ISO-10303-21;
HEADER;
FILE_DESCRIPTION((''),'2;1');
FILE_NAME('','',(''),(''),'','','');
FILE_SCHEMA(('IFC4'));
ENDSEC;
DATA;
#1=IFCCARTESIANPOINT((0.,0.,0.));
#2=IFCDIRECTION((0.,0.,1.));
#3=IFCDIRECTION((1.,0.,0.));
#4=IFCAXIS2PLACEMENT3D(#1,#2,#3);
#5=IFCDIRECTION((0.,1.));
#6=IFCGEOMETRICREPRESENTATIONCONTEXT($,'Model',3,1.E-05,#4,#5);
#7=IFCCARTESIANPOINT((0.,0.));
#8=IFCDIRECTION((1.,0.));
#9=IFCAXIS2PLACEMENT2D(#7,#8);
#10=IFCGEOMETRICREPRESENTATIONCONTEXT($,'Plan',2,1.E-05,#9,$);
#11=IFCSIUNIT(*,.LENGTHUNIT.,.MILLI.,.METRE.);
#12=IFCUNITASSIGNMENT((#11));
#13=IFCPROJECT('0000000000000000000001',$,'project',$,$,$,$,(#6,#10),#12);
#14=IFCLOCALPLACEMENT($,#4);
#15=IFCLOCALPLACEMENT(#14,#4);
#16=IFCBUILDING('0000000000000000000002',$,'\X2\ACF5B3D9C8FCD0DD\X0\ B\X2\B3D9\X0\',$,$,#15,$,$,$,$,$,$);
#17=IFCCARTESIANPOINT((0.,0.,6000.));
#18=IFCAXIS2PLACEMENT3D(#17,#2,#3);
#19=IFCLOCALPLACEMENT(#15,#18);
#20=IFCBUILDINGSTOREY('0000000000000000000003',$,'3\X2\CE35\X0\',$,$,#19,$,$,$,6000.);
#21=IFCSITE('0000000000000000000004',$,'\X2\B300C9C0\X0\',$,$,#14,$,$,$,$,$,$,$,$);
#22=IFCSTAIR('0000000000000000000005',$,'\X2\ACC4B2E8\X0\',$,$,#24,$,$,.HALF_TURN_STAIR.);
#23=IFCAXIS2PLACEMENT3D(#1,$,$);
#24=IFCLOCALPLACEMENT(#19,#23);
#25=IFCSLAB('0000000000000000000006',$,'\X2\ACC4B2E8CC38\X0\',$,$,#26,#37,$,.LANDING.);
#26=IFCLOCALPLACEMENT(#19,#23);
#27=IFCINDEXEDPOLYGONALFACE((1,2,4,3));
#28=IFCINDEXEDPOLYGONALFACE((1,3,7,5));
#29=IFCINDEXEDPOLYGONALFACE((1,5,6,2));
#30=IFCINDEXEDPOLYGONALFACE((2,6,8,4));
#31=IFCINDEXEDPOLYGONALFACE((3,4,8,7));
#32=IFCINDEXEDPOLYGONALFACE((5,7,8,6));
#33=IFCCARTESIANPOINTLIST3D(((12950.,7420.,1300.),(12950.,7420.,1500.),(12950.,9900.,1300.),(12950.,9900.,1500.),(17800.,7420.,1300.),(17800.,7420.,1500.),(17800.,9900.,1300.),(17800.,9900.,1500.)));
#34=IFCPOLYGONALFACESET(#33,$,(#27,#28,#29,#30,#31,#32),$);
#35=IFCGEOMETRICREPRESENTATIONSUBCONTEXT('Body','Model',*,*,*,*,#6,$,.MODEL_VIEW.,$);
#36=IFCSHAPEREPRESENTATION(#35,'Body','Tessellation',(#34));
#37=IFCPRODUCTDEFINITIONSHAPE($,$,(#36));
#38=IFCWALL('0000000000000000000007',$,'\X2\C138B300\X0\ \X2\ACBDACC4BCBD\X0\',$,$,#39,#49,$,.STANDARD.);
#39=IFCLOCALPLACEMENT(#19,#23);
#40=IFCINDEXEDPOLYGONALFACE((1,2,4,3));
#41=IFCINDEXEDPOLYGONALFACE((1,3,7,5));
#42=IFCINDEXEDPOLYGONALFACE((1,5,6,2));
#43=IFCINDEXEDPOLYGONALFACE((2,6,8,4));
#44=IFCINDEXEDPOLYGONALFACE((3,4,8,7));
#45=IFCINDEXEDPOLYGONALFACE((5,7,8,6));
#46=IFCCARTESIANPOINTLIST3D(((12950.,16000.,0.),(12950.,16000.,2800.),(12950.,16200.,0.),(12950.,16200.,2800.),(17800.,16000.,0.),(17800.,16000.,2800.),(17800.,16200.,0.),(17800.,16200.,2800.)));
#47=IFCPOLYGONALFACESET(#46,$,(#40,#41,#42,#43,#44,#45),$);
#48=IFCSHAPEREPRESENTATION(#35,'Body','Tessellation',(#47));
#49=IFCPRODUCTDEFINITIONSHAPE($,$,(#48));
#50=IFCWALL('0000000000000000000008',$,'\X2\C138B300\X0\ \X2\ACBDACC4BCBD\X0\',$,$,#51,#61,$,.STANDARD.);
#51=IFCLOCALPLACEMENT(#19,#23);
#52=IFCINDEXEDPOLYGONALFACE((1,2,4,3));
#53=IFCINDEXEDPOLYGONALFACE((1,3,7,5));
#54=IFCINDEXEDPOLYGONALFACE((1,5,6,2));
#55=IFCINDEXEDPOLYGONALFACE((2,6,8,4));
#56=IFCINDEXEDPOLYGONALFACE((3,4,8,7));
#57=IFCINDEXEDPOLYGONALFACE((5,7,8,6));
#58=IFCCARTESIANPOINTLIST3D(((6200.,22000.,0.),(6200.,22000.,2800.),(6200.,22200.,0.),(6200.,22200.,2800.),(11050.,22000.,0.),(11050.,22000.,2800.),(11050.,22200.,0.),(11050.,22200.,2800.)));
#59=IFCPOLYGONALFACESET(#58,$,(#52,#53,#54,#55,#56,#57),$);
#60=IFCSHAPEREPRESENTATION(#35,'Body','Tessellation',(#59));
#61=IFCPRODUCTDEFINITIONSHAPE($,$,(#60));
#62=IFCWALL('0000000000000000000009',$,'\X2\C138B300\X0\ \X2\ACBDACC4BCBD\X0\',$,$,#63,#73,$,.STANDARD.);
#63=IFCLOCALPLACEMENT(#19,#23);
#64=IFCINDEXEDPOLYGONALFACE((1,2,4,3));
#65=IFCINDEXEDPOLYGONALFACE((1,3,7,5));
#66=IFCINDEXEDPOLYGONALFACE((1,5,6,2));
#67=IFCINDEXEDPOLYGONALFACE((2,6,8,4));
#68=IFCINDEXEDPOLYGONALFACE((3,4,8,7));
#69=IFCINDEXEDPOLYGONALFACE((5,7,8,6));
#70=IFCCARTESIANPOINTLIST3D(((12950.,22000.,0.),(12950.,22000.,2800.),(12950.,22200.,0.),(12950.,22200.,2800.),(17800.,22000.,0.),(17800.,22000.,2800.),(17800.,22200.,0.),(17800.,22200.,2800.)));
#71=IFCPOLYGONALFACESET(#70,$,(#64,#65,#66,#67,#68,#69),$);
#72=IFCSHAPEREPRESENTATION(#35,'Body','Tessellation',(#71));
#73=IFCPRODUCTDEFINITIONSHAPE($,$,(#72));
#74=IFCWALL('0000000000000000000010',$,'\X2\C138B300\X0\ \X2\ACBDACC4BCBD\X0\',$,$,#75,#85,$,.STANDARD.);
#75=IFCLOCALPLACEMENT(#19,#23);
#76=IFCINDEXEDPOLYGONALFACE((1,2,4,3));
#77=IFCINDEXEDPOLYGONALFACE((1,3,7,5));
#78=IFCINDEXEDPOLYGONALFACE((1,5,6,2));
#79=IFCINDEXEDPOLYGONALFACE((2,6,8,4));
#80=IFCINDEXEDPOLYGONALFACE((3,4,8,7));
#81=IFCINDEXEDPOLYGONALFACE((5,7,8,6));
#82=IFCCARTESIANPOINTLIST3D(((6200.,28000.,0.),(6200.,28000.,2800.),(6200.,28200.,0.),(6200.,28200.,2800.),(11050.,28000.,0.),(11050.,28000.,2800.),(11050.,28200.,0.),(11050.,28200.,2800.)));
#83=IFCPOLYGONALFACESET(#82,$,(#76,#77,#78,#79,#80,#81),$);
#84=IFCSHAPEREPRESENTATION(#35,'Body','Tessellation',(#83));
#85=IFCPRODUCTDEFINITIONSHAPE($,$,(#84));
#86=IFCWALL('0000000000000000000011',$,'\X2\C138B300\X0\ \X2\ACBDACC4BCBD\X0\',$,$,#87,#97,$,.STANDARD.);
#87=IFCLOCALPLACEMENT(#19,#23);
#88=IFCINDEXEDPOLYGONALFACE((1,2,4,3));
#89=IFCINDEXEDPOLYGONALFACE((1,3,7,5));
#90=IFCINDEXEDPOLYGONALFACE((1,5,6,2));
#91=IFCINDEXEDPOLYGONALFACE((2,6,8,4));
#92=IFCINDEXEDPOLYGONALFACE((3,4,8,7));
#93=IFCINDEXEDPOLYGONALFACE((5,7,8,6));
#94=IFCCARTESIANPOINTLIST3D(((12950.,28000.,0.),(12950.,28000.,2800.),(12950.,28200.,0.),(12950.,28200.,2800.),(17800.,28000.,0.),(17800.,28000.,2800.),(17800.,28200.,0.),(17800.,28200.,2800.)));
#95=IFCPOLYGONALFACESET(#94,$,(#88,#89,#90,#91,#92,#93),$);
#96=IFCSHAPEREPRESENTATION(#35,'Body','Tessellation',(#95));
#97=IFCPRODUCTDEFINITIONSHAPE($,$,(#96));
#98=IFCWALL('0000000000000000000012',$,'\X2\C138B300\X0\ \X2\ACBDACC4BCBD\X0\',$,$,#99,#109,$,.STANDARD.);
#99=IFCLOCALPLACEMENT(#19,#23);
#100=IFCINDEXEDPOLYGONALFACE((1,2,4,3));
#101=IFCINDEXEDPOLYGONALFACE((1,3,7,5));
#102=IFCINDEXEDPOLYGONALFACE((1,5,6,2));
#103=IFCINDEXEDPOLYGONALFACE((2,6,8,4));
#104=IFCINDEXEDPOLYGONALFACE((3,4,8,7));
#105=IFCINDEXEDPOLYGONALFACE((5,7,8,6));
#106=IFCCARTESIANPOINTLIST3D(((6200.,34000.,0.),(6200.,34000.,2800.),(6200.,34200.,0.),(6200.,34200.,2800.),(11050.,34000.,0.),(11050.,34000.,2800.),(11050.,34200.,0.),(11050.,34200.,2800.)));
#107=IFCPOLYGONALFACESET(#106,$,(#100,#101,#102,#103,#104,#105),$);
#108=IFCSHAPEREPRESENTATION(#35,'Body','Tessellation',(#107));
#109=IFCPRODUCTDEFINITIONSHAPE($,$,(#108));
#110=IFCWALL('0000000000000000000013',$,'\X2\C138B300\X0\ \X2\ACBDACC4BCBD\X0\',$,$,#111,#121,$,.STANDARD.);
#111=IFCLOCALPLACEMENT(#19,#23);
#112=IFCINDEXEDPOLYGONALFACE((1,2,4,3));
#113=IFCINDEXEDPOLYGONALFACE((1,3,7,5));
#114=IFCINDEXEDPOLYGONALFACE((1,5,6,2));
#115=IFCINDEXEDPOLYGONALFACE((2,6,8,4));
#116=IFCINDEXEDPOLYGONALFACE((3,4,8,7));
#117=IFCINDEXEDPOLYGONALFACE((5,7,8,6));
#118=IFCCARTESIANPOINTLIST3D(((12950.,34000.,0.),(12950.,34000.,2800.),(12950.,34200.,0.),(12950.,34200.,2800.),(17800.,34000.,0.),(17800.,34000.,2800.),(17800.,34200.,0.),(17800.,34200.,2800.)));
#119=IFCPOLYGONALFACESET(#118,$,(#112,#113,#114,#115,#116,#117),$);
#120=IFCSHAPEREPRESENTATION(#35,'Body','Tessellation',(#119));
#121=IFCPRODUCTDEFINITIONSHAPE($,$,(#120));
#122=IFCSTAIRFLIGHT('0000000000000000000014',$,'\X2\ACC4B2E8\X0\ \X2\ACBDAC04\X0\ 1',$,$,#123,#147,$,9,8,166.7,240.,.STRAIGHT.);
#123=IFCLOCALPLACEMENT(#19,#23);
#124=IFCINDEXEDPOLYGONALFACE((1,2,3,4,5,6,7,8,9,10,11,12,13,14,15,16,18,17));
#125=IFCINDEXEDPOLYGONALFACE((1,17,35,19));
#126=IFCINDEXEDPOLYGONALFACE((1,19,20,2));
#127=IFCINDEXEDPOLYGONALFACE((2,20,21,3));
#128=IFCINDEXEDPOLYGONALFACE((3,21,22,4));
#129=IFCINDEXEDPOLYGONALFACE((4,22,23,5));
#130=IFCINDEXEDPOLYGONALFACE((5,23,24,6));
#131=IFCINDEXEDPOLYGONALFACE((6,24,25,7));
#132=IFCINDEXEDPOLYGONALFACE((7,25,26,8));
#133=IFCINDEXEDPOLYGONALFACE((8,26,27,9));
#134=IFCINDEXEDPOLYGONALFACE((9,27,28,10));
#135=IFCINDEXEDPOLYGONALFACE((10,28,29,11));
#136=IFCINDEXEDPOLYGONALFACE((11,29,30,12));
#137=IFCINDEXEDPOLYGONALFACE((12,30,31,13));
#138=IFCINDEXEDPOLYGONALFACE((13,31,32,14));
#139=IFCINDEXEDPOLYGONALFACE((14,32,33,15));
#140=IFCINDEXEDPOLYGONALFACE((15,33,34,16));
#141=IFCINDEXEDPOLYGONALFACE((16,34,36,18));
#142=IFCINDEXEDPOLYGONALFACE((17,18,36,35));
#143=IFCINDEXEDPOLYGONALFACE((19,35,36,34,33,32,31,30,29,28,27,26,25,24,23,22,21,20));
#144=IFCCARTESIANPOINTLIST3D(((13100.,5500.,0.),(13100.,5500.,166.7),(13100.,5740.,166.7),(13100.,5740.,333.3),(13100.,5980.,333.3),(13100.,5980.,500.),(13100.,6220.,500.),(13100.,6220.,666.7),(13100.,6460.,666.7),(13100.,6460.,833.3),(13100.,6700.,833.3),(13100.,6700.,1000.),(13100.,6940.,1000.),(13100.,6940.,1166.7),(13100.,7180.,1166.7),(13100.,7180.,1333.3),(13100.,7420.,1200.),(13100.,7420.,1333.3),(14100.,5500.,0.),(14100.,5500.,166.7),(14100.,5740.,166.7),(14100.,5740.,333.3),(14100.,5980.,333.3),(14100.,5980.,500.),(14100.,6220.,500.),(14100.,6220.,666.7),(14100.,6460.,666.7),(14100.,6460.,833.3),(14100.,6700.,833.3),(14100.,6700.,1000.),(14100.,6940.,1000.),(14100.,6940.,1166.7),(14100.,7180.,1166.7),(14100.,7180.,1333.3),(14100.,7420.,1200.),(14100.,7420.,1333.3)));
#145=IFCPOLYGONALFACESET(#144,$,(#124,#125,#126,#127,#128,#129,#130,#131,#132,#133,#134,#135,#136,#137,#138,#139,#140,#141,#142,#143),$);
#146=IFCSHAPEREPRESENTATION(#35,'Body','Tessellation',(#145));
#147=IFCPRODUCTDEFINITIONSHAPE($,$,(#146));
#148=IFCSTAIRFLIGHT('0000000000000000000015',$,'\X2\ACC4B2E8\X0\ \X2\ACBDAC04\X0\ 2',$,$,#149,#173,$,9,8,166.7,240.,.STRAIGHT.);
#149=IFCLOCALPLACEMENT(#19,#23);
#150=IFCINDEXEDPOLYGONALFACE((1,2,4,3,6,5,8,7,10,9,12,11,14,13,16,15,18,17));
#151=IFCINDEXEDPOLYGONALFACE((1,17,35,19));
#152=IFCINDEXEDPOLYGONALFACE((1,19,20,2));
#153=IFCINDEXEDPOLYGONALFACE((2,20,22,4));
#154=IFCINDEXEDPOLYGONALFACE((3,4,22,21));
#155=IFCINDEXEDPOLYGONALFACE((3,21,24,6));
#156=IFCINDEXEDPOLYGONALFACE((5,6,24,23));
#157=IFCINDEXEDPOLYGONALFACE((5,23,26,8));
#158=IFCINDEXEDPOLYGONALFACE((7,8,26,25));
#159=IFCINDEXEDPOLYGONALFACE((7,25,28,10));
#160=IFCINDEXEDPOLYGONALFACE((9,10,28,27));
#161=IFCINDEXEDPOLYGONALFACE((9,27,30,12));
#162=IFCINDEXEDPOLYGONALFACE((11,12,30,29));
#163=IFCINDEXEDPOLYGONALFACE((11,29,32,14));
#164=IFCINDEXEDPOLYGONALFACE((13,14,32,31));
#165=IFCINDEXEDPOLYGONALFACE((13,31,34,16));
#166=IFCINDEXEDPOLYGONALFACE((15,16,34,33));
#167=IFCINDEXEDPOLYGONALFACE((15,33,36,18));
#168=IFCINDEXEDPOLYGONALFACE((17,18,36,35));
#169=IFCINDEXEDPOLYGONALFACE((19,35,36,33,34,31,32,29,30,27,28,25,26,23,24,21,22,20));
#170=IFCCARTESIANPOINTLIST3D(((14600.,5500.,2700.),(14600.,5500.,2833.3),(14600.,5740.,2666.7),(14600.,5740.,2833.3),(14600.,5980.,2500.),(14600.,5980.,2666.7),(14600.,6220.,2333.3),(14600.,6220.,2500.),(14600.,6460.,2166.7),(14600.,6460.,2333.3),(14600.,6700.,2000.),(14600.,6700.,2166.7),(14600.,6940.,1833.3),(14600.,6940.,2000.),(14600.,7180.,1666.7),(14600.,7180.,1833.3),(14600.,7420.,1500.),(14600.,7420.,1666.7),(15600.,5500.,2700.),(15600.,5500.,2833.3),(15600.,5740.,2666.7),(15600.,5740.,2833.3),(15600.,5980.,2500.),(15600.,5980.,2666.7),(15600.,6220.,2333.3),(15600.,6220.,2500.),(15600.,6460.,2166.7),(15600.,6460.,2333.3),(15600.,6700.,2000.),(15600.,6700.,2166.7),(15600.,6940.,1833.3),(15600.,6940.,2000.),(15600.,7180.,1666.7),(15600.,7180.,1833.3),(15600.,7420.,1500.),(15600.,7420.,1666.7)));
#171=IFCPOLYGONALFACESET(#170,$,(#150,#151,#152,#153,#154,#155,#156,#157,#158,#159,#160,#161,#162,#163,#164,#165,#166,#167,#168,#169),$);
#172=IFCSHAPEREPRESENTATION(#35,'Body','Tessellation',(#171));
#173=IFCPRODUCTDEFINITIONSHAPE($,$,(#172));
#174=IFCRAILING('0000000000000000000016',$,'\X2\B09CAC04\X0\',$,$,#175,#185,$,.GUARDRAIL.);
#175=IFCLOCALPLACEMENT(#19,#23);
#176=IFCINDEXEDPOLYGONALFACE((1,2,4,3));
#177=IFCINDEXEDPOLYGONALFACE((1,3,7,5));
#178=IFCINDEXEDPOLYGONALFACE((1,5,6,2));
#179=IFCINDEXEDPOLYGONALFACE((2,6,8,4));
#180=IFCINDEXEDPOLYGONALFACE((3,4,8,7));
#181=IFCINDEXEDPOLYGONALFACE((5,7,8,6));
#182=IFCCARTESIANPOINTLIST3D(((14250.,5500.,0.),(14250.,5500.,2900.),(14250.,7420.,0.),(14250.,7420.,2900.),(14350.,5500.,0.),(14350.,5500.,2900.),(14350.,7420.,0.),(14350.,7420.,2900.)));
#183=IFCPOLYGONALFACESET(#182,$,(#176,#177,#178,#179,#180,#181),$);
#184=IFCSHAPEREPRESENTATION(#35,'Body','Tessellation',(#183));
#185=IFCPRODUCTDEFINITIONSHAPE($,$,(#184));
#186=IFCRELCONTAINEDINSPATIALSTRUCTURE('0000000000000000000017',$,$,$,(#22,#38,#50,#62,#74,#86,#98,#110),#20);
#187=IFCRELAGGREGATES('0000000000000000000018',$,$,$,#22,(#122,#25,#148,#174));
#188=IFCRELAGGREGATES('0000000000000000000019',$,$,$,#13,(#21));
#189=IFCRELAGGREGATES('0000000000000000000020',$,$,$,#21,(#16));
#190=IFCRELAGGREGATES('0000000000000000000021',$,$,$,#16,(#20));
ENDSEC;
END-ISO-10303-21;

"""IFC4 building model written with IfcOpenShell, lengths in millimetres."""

from ifc_helpers import new_model, si_unit, direction, frame, origin_with_axes, origin_2d_with_axis, place, context, subcontext, project, spatial, polyline, outline, extrude, element, aggregate, save


model = new_model("IFC4")

# Units and contexts
model_context = context("Model", 3, precision=1e-05, world=origin_with_axes(), true_north=direction((0.0, 1.0)))
plan_context = context("Plan", 2, precision=1e-05, world=origin_2d_with_axis())
body_context = subcontext(model_context, "Body", "Model", "MODEL_VIEW")
ifc_project = project(units=[si_unit("LENGTHUNIT", "METRE", prefix="MILLI")], contexts=[model_context, plan_context])

# Site, building, storey
site_placement = place(None, origin_with_axes())
site = spatial("IfcSite", under=ifc_project, at=site_placement, Name="대지")
building_placement = place(site_placement, origin_with_axes())
building = spatial("IfcBuilding", under=site, at=building_placement, Name="공동주택 B동")
storey_placement = place(building_placement, frame((0.0, 0.0, 6000.0), z_axis=(0.0, 0.0, 1.0), x_axis=(1.0, 0.0, 0.0)))
storey = spatial("IfcBuildingStorey", under=building, at=storey_placement, Name="3층", Elevation=6000.0)

# Stair, slab
stair_placement = place(storey_placement, origin_with_axes())
stair = element("IfcStair", 1, at=stair_placement, inside=storey, Name="계단", PredefinedType="HALF_TURN_STAIR")
slab_placement = place(stair_placement, origin_with_axes())
slab = element("IfcSlab", 2, at=slab_placement, Name="계단참", PredefinedType="LANDING", context=body_context, shape_type="SweptSolid", body=[
    extrude(outline(polyline([(12950.0, 7420.0), (17800.0, 7420.0), (17800.0, 9900.0), (12950.0, 9900.0), (12950.0, 7420.0)])), frame((0.0, 0.0, 1300.0), z_axis=(0.0, 0.0, 1.0), x_axis=(1.0, 0.0, 0.0)), (0.0, 0.0, 1.0), 200.0),
])

# Walls
wall_1_placement = place(storey_placement, origin_with_axes())
element("IfcWall", 3, at=wall_1_placement, inside=storey, Name="세대 경계벽", PredefinedType="STANDARD", context=body_context, shape_type="SweptSolid", body=[
    extrude(outline(polyline([(12950.0, 16200.0), (17800.0, 16200.0), (17800.0, 16000.0), (12950.0, 16000.0), (12950.0, 16200.0)])), origin_with_axes(), (0.0, 0.0, 1.0), 2800.0),
])
wall_2_placement = place(storey_placement, origin_with_axes())
element("IfcWall", 4, at=wall_2_placement, inside=storey, Name="세대 경계벽", PredefinedType="STANDARD", context=body_context, shape_type="SweptSolid", body=[
    extrude(outline(polyline([(6200.0, 22200.0), (11050.0, 22200.0), (11050.0, 22000.0), (6200.0, 22000.0), (6200.0, 22200.0)])), origin_with_axes(), (0.0, 0.0, 1.0), 2800.0),
])
wall_3_placement = place(storey_placement, origin_with_axes())
element("IfcWall", 5, at=wall_3_placement, inside=storey, Name="세대 경계벽", PredefinedType="STANDARD", context=body_context, shape_type="SweptSolid", body=[
    extrude(outline(polyline([(12950.0, 22200.0), (17800.0, 22200.0), (17800.0, 22000.0), (12950.0, 22000.0), (12950.0, 22200.0)])), origin_with_axes(), (0.0, 0.0, 1.0), 2800.0),
])
wall_4_placement = place(storey_placement, origin_with_axes())
element("IfcWall", 6, at=wall_4_placement, inside=storey, Name="세대 경계벽", PredefinedType="STANDARD", context=body_context, shape_type="SweptSolid", body=[
    extrude(outline(polyline([(6200.0, 28200.0), (11050.0, 28200.0), (11050.0, 28000.0), (6200.0, 28000.0), (6200.0, 28200.0)])), origin_with_axes(), (0.0, 0.0, 1.0), 2800.0),
])
wall_5_placement = place(storey_placement, origin_with_axes())
element("IfcWall", 7, at=wall_5_placement, inside=storey, Name="세대 경계벽", PredefinedType="STANDARD", context=body_context, shape_type="SweptSolid", body=[
    extrude(outline(polyline([(12950.0, 28200.0), (17800.0, 28200.0), (17800.0, 28000.0), (12950.0, 28000.0), (12950.0, 28200.0)])), origin_with_axes(), (0.0, 0.0, 1.0), 2800.0),
])
wall_6_placement = place(storey_placement, origin_with_axes())
element("IfcWall", 8, at=wall_6_placement, inside=storey, Name="세대 경계벽", PredefinedType="STANDARD", context=body_context, shape_type="SweptSolid", body=[
    extrude(outline(polyline([(6200.0, 34200.0), (11050.0, 34200.0), (11050.0, 34000.0), (6200.0, 34000.0), (6200.0, 34200.0)])), origin_with_axes(), (0.0, 0.0, 1.0), 2800.0),
])
wall_7_placement = place(storey_placement, origin_with_axes())
element("IfcWall", 9, at=wall_7_placement, inside=storey, Name="세대 경계벽", PredefinedType="STANDARD", context=body_context, shape_type="SweptSolid", body=[
    extrude(outline(polyline([(12950.0, 34200.0), (17800.0, 34200.0), (17800.0, 34000.0), (12950.0, 34000.0), (12950.0, 34200.0)])), origin_with_axes(), (0.0, 0.0, 1.0), 2800.0),
])

# Stair flights
stair_flight_1_placement = place(stair_placement, origin_with_axes())
stair_flight_1 = element("IfcStairFlight", 10, at=stair_flight_1_placement, Name="계단 경간 1", NumberOfRisers=9, NumberOfTreads=8, PredefinedType="STRAIGHT", RiserHeight=166.7, TreadLength=240.0, context=body_context, shape_type="SweptSolid", body=[
    extrude(outline(polyline([(0.0, 0.0), (0.0, 166.7), (240.0, 166.7), (240.0, 333.3), (480.0, 333.3), (480.0, 500.0), (720.0, 500.0), (720.0, 666.7), (960.0, 666.7), (960.0, 833.3), (1200.0, 833.3), (1200.0, 1000.0), (1440.0, 1000.0), (1440.0, 1166.7), (1680.0, 1166.7), (1680.0, 1333.3), (1920.0, 1333.3), (1920.0, 1500.0), (1920.0, 1200.0), (0.0, 0.0)])), frame((13100.0, 5500.0, 0.0), z_axis=(1.0, 0.0, 0.0), x_axis=(0.0, 1.0, 0.0)), (0.0, 0.0, 1.0), 1000.0),
])
stair_flight_2_placement = place(stair_placement, origin_with_axes())
stair_flight_2 = element("IfcStairFlight", 11, at=stair_flight_2_placement, Name="계단 경간 2", NumberOfRisers=9, NumberOfTreads=8, PredefinedType="STRAIGHT", RiserHeight=166.7, TreadLength=240.0, context=body_context, shape_type="SweptSolid", body=[
    extrude(outline(polyline([(0.0, 0.0), (0.0, 166.7), (240.0, 166.7), (240.0, 333.3), (480.0, 333.3), (480.0, 500.0), (720.0, 500.0), (720.0, 666.7), (960.0, 666.7), (960.0, 833.3), (1200.0, 833.3), (1200.0, 1000.0), (1440.0, 1000.0), (1440.0, 1166.7), (1680.0, 1166.7), (1680.0, 1333.3), (1920.0, 1333.3), (1920.0, 1500.0), (1920.0, 1200.0), (0.0, 0.0)])), frame((15600.0, 7420.0, 1500.0), z_axis=(-1.0, 0.0, 0.0), x_axis=(0.0, -1.0, 0.0)), (0.0, 0.0, 1.0), 1000.0),
])

# Railing
railing_placement = place(stair_placement, origin_with_axes())
railing = element("IfcRailing", 12, at=railing_placement, Name="난간", PredefinedType="GUARDRAIL", context=body_context, shape_type="SweptSolid", body=[
    extrude(outline(polyline([(14250.0, 5500.0), (14350.0, 5500.0), (14350.0, 7420.0), (14250.0, 7420.0), (14250.0, 5500.0)])), origin_with_axes(), (0.0, 0.0, 1.0), 2900.0),
])
aggregate(stair, [stair_flight_1, slab, stair_flight_2, railing])

save(model, "model.ifc")
